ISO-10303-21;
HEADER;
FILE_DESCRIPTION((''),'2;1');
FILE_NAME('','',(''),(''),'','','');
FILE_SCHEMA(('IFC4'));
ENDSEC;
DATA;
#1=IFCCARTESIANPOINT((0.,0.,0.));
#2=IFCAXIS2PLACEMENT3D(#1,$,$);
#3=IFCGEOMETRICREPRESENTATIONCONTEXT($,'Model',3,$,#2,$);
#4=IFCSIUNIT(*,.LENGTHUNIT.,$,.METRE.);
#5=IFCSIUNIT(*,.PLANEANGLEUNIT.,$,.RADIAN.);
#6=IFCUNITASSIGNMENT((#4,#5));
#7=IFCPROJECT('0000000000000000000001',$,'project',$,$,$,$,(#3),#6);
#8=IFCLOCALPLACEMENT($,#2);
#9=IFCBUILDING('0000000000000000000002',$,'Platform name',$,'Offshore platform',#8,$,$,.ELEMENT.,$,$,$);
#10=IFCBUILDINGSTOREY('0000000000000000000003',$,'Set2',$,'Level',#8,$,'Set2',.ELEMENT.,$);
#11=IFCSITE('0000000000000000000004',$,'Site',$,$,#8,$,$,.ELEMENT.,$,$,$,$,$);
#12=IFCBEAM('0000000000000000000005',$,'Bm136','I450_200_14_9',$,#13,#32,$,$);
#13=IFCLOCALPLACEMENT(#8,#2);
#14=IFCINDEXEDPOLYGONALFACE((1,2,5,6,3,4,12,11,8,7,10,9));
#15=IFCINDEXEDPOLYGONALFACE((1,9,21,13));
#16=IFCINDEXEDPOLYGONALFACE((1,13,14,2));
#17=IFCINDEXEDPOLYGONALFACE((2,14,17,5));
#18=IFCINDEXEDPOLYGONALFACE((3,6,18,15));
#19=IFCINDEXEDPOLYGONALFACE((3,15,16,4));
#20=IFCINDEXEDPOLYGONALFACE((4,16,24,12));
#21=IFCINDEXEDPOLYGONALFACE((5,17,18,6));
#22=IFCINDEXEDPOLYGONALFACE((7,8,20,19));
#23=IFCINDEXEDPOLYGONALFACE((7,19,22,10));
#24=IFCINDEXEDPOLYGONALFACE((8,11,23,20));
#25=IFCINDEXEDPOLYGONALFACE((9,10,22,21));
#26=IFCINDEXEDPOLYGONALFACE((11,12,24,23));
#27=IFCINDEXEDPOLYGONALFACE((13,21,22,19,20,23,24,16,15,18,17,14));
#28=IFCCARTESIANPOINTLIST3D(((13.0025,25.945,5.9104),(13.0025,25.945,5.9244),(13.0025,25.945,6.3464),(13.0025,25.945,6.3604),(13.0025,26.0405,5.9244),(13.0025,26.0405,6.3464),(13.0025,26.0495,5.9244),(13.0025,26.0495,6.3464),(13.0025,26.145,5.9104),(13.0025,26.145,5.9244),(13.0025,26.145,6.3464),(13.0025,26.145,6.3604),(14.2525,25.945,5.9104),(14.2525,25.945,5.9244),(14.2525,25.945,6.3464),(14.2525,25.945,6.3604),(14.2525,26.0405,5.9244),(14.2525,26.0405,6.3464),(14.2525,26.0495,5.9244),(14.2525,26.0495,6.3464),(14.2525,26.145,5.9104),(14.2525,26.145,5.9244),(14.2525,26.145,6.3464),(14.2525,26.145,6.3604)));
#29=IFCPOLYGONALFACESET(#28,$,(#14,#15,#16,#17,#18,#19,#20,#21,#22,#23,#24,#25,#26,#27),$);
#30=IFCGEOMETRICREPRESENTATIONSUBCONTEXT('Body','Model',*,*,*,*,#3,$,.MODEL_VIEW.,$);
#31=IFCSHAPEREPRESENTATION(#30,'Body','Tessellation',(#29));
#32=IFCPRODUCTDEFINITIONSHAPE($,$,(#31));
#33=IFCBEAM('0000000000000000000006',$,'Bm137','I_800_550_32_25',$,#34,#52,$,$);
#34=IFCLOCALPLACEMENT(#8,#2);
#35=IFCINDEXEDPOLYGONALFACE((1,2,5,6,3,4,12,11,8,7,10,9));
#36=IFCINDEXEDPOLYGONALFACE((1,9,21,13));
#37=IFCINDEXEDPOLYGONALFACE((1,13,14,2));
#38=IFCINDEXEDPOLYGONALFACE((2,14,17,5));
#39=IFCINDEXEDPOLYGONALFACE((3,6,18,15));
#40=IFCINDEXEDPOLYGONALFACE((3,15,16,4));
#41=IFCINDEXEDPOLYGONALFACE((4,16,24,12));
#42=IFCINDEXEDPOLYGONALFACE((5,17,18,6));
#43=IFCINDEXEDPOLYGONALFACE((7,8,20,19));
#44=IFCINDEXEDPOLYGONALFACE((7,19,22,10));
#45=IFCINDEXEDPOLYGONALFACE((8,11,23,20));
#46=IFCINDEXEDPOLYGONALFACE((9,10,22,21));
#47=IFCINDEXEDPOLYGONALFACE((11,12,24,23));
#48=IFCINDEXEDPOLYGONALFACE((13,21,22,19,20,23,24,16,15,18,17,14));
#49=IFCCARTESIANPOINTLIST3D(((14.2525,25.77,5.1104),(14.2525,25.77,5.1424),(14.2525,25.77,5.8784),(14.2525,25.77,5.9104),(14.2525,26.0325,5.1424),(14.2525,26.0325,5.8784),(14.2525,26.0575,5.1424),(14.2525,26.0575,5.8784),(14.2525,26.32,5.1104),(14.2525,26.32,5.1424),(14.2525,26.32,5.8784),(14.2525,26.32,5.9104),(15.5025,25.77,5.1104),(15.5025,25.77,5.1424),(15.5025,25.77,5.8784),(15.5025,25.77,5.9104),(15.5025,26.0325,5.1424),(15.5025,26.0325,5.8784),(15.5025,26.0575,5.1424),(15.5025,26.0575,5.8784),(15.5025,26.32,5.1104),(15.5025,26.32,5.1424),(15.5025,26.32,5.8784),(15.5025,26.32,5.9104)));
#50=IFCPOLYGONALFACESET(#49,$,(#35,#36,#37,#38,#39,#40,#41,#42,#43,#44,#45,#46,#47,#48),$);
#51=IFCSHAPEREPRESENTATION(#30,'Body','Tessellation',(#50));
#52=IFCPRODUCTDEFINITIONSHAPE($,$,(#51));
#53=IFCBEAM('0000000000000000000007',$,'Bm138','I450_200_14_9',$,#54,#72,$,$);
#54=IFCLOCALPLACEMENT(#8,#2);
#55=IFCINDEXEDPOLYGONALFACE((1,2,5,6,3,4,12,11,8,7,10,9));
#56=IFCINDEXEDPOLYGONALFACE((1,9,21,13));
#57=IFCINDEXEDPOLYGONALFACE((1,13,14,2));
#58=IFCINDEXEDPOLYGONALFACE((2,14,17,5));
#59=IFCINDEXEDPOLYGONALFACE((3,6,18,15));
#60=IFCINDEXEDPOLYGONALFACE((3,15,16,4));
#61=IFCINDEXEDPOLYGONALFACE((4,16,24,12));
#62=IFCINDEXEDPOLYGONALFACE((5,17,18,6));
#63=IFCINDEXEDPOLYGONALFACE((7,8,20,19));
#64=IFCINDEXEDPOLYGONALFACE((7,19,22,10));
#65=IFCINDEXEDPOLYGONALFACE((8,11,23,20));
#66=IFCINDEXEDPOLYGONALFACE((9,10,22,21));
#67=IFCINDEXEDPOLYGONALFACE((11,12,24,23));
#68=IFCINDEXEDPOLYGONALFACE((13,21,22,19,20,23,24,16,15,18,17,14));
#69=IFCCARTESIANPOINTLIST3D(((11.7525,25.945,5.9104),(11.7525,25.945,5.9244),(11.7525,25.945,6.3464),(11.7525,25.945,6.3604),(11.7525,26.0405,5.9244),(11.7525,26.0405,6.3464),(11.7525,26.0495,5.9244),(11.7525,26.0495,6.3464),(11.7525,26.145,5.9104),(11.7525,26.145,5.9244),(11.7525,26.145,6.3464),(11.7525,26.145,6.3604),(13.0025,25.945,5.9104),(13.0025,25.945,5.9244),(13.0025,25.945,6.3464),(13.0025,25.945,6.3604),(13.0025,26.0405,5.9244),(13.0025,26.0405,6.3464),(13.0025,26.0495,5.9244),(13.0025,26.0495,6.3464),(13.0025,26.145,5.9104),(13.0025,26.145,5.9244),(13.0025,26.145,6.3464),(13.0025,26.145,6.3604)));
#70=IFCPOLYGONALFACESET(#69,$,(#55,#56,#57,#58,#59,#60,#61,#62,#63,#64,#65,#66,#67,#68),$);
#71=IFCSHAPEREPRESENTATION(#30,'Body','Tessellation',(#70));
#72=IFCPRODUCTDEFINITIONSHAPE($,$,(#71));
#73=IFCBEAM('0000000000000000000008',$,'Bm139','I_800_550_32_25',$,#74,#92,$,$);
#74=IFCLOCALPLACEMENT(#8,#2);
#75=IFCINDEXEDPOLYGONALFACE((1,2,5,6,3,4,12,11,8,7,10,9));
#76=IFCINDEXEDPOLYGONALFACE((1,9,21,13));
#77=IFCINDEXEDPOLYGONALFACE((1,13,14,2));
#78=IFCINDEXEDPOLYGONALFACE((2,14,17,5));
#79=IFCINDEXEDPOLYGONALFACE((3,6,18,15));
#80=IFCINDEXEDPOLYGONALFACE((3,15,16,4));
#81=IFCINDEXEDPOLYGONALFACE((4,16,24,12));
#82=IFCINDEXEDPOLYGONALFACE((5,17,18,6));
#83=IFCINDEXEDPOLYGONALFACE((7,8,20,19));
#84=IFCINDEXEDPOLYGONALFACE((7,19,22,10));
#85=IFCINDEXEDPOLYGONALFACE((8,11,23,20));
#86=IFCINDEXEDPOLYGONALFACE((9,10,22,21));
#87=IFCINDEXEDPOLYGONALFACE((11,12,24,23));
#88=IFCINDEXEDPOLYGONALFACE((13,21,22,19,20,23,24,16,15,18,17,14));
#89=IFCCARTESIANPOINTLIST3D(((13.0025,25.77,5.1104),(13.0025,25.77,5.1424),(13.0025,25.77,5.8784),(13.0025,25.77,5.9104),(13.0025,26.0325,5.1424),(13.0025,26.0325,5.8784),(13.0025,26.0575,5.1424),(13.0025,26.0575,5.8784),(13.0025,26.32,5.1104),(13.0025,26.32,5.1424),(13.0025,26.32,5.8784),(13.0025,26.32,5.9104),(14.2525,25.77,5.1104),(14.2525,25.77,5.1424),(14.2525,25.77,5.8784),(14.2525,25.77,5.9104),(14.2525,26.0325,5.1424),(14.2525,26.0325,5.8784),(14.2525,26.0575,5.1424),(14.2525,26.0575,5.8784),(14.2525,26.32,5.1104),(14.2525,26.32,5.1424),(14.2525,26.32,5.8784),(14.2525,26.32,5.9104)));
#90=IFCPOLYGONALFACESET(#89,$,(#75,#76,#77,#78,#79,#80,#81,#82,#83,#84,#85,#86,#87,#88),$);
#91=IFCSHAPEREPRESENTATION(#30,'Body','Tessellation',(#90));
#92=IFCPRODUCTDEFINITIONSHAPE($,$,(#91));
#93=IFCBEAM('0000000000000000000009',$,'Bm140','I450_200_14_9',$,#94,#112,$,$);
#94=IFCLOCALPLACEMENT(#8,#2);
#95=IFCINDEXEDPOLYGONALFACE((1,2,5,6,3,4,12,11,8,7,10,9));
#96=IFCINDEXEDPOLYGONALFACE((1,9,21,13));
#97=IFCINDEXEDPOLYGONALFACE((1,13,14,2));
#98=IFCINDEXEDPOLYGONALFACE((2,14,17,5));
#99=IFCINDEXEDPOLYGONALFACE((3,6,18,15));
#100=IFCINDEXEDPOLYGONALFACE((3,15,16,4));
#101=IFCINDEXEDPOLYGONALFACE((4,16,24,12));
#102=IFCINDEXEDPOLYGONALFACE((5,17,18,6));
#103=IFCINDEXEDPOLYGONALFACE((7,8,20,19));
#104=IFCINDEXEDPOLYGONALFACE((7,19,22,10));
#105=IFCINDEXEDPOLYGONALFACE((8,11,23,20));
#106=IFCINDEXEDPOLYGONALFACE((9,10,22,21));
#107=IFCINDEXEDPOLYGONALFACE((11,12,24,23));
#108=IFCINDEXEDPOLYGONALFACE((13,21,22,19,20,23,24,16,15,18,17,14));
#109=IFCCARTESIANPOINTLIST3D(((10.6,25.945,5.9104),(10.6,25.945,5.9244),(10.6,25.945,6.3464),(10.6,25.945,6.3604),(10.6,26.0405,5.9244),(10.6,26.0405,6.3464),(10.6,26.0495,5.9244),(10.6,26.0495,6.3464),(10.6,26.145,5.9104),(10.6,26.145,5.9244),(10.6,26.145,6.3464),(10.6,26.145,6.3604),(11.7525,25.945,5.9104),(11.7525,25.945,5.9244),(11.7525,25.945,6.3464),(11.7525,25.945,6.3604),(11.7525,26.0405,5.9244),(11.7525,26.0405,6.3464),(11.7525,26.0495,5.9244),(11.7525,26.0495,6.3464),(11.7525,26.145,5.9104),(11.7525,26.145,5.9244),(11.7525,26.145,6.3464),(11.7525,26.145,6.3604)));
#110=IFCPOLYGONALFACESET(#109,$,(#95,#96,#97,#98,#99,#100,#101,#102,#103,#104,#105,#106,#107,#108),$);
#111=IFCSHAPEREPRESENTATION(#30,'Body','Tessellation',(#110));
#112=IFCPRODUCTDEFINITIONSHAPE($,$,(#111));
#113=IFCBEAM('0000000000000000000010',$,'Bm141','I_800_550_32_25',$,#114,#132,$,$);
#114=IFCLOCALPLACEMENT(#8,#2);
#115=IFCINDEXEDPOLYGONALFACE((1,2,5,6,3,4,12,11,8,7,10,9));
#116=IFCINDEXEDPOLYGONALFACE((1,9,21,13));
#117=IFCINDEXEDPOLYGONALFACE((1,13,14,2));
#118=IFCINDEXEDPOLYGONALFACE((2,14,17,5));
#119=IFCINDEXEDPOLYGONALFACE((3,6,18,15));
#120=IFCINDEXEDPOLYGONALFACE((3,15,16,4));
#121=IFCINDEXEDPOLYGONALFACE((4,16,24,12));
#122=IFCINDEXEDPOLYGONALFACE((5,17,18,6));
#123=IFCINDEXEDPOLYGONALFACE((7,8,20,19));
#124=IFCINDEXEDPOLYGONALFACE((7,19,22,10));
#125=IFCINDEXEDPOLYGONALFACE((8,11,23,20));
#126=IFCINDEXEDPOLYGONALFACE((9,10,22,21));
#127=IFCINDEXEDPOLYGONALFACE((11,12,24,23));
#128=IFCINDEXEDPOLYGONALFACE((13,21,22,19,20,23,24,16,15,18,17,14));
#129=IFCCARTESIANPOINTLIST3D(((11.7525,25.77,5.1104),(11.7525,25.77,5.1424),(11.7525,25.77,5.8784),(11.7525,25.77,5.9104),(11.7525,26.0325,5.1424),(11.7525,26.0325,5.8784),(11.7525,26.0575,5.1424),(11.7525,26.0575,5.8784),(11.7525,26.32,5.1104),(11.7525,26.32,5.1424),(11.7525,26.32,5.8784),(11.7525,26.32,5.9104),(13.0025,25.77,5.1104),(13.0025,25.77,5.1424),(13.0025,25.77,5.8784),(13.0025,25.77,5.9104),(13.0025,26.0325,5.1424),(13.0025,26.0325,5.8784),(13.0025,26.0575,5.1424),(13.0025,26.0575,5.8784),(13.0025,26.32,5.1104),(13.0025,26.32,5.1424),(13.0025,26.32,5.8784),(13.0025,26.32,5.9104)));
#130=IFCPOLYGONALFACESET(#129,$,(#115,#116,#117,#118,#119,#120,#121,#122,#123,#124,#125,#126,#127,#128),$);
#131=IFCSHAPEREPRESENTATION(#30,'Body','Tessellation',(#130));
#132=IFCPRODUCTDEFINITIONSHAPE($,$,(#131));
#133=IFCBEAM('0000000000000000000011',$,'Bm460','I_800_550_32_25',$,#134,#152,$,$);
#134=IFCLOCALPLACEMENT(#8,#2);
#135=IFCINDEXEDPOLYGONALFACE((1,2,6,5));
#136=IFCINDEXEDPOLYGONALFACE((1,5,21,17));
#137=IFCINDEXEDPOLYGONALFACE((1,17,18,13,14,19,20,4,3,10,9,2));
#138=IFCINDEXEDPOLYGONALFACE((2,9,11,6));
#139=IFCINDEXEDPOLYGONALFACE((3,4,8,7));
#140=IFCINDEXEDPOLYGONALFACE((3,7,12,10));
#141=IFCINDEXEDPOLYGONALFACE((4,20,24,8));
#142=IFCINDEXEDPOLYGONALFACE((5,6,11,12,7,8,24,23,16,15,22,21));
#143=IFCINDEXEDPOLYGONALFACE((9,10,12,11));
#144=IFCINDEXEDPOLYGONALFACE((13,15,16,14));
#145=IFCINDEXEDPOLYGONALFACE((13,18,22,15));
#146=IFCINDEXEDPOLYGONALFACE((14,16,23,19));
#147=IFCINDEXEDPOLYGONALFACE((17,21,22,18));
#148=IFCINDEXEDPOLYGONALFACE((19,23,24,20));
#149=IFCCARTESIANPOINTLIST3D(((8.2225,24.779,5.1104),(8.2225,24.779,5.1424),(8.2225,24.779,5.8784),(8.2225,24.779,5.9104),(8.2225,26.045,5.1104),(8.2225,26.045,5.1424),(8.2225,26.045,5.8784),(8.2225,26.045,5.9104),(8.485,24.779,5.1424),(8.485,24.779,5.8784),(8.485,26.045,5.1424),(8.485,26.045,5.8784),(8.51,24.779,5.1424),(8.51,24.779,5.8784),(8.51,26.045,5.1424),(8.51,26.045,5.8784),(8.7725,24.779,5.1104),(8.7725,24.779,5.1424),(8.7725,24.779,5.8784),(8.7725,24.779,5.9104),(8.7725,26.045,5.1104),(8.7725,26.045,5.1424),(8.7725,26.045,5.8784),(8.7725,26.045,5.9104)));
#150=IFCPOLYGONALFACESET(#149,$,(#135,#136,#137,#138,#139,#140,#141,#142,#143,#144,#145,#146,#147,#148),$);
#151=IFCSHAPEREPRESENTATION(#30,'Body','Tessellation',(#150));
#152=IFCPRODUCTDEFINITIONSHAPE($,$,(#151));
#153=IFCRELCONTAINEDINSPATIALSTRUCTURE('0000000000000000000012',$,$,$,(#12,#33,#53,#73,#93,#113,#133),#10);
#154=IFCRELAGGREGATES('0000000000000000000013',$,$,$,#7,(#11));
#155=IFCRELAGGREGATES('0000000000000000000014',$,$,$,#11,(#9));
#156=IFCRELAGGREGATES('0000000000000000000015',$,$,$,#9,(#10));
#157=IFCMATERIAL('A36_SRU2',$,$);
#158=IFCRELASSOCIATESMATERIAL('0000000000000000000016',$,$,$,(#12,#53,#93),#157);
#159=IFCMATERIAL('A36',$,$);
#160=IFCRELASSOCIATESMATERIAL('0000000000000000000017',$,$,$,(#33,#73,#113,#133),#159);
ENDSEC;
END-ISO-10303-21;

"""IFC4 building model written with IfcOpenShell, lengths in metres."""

from ifc_helpers import new_model, si_unit, frame, origin, origin_2d, place, context, subcontext, project, spatial, i_section, extrude, source, transform, mapped, material, element, save


model = new_model("IFC4")

# Units and contexts
model_context = context("Model", 3, world=origin())
body_context = subcontext(model_context, "Body", "Model", "MODEL_VIEW")
ifc_project = project(units=[si_unit("LENGTHUNIT", "METRE"), si_unit("PLANEANGLEUNIT", "RADIAN")], contexts=[model_context])

# Site, building, storey
placement_1 = place(None, origin())
site = spatial("IfcSite", under=ifc_project, at=placement_1, Name="Site", CompositionType="ELEMENT")
building = spatial("IfcBuilding", under=site, at=placement_1, Name="Platform name", ObjectType="Offshore platform", CompositionType="ELEMENT")
storey = spatial("IfcBuildingStorey", under=building, at=placement_1, Name="Set2", ObjectType="Level", LongName="Set2", CompositionType="ELEMENT")

# Beams
ifc_material_1 = material(Name="A36_SRU2")
ifc_material_2 = material(Name="A36")
shared_shape_1 = source(origin(), body_context, "Body", "SweptSolid", [
    extrude(i_section(OverallWidth=0.2, OverallDepth=0.45, WebThickness=0.009, FlangeThickness=0.014, FilletRadius=0.0, at=origin_2d()), frame((0.0, 0.0, 0.0), z_axis=(-1.0, 0.0, 0.0), x_axis=(0.0, -1.0, 0.0)), (0.0, 0.0, 1.0), 1.25),
])
placement_2 = place(None, origin())
placement_3 = place(placement_2, origin())
placement_4 = place(placement_3, origin())
beam_1_placement = place(placement_4, frame((14.2525, 26.045, 6.1354)))
element("IfcBeam", 1, at=beam_1_placement, inside=storey, material=ifc_material_1, Name="Bm136", Description="I450_200_14_9", context=body_context, shape_type="MappedRepresentation", body=[
    mapped(shared_shape_1, transform((0.0, 0.0, 0.0), scale=1.0)),
])
shared_shape_2 = source(origin(), body_context, "Body", "SweptSolid", [
    extrude(i_section(OverallWidth=0.55, OverallDepth=0.8, WebThickness=0.025, FlangeThickness=0.032, FilletRadius=0.0, at=origin_2d()), frame((0.0, 0.0, 0.0), z_axis=(1.0, 0.0, 0.0), x_axis=(0.0, 1.0, 0.0)), (0.0, 0.0, 1.0), 1.25),
])
placement_5 = place(None, origin())
placement_6 = place(placement_5, origin())
placement_7 = place(placement_6, origin())
beam_2_placement = place(placement_7, frame((14.2525, 26.045, 5.5104)))
element("IfcBeam", 2, at=beam_2_placement, inside=storey, material=ifc_material_2, Name="Bm137", Description="I_800_550_32_25", context=body_context, shape_type="MappedRepresentation", body=[
    mapped(shared_shape_2, transform((0.0, 0.0, 0.0), scale=1.0)),
])
shared_shape_3 = source(origin(), body_context, "Body", "SweptSolid", [
    extrude(i_section(OverallWidth=0.2, OverallDepth=0.45, WebThickness=0.009, FlangeThickness=0.014, FilletRadius=0.0, at=origin_2d()), frame((0.0, 0.0, 0.0), z_axis=(-1.0, 0.0, 0.0), x_axis=(0.0, -1.0, 0.0)), (0.0, 0.0, 1.0), 1.25),
])
placement_8 = place(None, origin())
placement_9 = place(placement_8, origin())
placement_10 = place(placement_9, origin())
beam_3_placement = place(placement_10, frame((13.0025, 26.045, 6.1354)))
element("IfcBeam", 3, at=beam_3_placement, inside=storey, material=ifc_material_1, Name="Bm138", Description="I450_200_14_9", context=body_context, shape_type="MappedRepresentation", body=[
    mapped(shared_shape_3, transform((0.0, 0.0, 0.0), scale=1.0)),
])
shared_shape_4 = source(origin(), body_context, "Body", "SweptSolid", [
    extrude(i_section(OverallWidth=0.55, OverallDepth=0.8, WebThickness=0.025, FlangeThickness=0.032, FilletRadius=0.0, at=origin_2d()), frame((0.0, 0.0, 0.0), z_axis=(1.0, 0.0, 0.0), x_axis=(0.0, 1.0, 0.0)), (0.0, 0.0, 1.0), 1.25),
])
placement_11 = place(None, origin())
placement_12 = place(placement_11, origin())
placement_13 = place(placement_12, origin())
beam_4_placement = place(placement_13, frame((13.0025, 26.045, 5.5104)))
element("IfcBeam", 4, at=beam_4_placement, inside=storey, material=ifc_material_2, Name="Bm139", Description="I_800_550_32_25", context=body_context, shape_type="MappedRepresentation", body=[
    mapped(shared_shape_4, transform((0.0, 0.0, 0.0), scale=1.0)),
])
shared_shape_5 = source(origin(), body_context, "Body", "SweptSolid", [
    extrude(i_section(OverallWidth=0.2, OverallDepth=0.45, WebThickness=0.009, FlangeThickness=0.014, FilletRadius=0.0, at=origin_2d()), frame((0.0, 0.0, 0.0), z_axis=(-1.0, 0.0, 0.0), x_axis=(0.0, -1.0, 0.0)), (0.0, 0.0, 1.0), 1.1525),
])
placement_14 = place(None, origin())
placement_15 = place(placement_14, origin())
placement_16 = place(placement_15, origin())
beam_5_placement = place(placement_16, frame((11.7525, 26.045, 6.1354)))
element("IfcBeam", 5, at=beam_5_placement, inside=storey, material=ifc_material_1, Name="Bm140", Description="I450_200_14_9", context=body_context, shape_type="MappedRepresentation", body=[
    mapped(shared_shape_5, transform((0.0, 0.0, 0.0), scale=1.0)),
])
shared_shape_6 = source(origin(), body_context, "Body", "SweptSolid", [
    extrude(i_section(OverallWidth=0.55, OverallDepth=0.8, WebThickness=0.025, FlangeThickness=0.032, FilletRadius=0.0, at=origin_2d()), frame((0.0, 0.0, 0.0), z_axis=(1.0, 0.0, 0.0), x_axis=(0.0, 1.0, 0.0)), (0.0, 0.0, 1.0), 1.25),
])
placement_17 = place(None, origin())
placement_18 = place(placement_17, origin())
placement_19 = place(placement_18, origin())
beam_6_placement = place(placement_19, frame((11.7525, 26.045, 5.5104)))
element("IfcBeam", 6, at=beam_6_placement, inside=storey, material=ifc_material_2, Name="Bm141", Description="I_800_550_32_25", context=body_context, shape_type="MappedRepresentation", body=[
    mapped(shared_shape_6, transform((0.0, 0.0, 0.0), scale=1.0)),
])
shared_shape_7 = source(origin(), body_context, "Body", "SweptSolid", [
    extrude(i_section(OverallWidth=0.55, OverallDepth=0.8, WebThickness=0.025, FlangeThickness=0.032, FilletRadius=0.0, at=origin_2d()), frame((0.0, 0.0, 0.0), z_axis=(0.0, -1.0, 0.0), x_axis=(1.0, 0.0, 0.0)), (0.0, 0.0, 1.0), 1.266),
])
placement_20 = place(None, origin())
placement_21 = place(placement_20, origin())
placement_22 = place(placement_21, origin())
beam_7_placement = place(placement_22, frame((8.4975, 26.045, 5.5104)))
element("IfcBeam", 7, at=beam_7_placement, inside=storey, material=ifc_material_2, Name="Bm460", Description="I_800_550_32_25", context=body_context, shape_type="MappedRepresentation", body=[
    mapped(shared_shape_7, transform((0.0, 0.0, 0.0), scale=1.0)),
])

save(model, "model.ifc")
